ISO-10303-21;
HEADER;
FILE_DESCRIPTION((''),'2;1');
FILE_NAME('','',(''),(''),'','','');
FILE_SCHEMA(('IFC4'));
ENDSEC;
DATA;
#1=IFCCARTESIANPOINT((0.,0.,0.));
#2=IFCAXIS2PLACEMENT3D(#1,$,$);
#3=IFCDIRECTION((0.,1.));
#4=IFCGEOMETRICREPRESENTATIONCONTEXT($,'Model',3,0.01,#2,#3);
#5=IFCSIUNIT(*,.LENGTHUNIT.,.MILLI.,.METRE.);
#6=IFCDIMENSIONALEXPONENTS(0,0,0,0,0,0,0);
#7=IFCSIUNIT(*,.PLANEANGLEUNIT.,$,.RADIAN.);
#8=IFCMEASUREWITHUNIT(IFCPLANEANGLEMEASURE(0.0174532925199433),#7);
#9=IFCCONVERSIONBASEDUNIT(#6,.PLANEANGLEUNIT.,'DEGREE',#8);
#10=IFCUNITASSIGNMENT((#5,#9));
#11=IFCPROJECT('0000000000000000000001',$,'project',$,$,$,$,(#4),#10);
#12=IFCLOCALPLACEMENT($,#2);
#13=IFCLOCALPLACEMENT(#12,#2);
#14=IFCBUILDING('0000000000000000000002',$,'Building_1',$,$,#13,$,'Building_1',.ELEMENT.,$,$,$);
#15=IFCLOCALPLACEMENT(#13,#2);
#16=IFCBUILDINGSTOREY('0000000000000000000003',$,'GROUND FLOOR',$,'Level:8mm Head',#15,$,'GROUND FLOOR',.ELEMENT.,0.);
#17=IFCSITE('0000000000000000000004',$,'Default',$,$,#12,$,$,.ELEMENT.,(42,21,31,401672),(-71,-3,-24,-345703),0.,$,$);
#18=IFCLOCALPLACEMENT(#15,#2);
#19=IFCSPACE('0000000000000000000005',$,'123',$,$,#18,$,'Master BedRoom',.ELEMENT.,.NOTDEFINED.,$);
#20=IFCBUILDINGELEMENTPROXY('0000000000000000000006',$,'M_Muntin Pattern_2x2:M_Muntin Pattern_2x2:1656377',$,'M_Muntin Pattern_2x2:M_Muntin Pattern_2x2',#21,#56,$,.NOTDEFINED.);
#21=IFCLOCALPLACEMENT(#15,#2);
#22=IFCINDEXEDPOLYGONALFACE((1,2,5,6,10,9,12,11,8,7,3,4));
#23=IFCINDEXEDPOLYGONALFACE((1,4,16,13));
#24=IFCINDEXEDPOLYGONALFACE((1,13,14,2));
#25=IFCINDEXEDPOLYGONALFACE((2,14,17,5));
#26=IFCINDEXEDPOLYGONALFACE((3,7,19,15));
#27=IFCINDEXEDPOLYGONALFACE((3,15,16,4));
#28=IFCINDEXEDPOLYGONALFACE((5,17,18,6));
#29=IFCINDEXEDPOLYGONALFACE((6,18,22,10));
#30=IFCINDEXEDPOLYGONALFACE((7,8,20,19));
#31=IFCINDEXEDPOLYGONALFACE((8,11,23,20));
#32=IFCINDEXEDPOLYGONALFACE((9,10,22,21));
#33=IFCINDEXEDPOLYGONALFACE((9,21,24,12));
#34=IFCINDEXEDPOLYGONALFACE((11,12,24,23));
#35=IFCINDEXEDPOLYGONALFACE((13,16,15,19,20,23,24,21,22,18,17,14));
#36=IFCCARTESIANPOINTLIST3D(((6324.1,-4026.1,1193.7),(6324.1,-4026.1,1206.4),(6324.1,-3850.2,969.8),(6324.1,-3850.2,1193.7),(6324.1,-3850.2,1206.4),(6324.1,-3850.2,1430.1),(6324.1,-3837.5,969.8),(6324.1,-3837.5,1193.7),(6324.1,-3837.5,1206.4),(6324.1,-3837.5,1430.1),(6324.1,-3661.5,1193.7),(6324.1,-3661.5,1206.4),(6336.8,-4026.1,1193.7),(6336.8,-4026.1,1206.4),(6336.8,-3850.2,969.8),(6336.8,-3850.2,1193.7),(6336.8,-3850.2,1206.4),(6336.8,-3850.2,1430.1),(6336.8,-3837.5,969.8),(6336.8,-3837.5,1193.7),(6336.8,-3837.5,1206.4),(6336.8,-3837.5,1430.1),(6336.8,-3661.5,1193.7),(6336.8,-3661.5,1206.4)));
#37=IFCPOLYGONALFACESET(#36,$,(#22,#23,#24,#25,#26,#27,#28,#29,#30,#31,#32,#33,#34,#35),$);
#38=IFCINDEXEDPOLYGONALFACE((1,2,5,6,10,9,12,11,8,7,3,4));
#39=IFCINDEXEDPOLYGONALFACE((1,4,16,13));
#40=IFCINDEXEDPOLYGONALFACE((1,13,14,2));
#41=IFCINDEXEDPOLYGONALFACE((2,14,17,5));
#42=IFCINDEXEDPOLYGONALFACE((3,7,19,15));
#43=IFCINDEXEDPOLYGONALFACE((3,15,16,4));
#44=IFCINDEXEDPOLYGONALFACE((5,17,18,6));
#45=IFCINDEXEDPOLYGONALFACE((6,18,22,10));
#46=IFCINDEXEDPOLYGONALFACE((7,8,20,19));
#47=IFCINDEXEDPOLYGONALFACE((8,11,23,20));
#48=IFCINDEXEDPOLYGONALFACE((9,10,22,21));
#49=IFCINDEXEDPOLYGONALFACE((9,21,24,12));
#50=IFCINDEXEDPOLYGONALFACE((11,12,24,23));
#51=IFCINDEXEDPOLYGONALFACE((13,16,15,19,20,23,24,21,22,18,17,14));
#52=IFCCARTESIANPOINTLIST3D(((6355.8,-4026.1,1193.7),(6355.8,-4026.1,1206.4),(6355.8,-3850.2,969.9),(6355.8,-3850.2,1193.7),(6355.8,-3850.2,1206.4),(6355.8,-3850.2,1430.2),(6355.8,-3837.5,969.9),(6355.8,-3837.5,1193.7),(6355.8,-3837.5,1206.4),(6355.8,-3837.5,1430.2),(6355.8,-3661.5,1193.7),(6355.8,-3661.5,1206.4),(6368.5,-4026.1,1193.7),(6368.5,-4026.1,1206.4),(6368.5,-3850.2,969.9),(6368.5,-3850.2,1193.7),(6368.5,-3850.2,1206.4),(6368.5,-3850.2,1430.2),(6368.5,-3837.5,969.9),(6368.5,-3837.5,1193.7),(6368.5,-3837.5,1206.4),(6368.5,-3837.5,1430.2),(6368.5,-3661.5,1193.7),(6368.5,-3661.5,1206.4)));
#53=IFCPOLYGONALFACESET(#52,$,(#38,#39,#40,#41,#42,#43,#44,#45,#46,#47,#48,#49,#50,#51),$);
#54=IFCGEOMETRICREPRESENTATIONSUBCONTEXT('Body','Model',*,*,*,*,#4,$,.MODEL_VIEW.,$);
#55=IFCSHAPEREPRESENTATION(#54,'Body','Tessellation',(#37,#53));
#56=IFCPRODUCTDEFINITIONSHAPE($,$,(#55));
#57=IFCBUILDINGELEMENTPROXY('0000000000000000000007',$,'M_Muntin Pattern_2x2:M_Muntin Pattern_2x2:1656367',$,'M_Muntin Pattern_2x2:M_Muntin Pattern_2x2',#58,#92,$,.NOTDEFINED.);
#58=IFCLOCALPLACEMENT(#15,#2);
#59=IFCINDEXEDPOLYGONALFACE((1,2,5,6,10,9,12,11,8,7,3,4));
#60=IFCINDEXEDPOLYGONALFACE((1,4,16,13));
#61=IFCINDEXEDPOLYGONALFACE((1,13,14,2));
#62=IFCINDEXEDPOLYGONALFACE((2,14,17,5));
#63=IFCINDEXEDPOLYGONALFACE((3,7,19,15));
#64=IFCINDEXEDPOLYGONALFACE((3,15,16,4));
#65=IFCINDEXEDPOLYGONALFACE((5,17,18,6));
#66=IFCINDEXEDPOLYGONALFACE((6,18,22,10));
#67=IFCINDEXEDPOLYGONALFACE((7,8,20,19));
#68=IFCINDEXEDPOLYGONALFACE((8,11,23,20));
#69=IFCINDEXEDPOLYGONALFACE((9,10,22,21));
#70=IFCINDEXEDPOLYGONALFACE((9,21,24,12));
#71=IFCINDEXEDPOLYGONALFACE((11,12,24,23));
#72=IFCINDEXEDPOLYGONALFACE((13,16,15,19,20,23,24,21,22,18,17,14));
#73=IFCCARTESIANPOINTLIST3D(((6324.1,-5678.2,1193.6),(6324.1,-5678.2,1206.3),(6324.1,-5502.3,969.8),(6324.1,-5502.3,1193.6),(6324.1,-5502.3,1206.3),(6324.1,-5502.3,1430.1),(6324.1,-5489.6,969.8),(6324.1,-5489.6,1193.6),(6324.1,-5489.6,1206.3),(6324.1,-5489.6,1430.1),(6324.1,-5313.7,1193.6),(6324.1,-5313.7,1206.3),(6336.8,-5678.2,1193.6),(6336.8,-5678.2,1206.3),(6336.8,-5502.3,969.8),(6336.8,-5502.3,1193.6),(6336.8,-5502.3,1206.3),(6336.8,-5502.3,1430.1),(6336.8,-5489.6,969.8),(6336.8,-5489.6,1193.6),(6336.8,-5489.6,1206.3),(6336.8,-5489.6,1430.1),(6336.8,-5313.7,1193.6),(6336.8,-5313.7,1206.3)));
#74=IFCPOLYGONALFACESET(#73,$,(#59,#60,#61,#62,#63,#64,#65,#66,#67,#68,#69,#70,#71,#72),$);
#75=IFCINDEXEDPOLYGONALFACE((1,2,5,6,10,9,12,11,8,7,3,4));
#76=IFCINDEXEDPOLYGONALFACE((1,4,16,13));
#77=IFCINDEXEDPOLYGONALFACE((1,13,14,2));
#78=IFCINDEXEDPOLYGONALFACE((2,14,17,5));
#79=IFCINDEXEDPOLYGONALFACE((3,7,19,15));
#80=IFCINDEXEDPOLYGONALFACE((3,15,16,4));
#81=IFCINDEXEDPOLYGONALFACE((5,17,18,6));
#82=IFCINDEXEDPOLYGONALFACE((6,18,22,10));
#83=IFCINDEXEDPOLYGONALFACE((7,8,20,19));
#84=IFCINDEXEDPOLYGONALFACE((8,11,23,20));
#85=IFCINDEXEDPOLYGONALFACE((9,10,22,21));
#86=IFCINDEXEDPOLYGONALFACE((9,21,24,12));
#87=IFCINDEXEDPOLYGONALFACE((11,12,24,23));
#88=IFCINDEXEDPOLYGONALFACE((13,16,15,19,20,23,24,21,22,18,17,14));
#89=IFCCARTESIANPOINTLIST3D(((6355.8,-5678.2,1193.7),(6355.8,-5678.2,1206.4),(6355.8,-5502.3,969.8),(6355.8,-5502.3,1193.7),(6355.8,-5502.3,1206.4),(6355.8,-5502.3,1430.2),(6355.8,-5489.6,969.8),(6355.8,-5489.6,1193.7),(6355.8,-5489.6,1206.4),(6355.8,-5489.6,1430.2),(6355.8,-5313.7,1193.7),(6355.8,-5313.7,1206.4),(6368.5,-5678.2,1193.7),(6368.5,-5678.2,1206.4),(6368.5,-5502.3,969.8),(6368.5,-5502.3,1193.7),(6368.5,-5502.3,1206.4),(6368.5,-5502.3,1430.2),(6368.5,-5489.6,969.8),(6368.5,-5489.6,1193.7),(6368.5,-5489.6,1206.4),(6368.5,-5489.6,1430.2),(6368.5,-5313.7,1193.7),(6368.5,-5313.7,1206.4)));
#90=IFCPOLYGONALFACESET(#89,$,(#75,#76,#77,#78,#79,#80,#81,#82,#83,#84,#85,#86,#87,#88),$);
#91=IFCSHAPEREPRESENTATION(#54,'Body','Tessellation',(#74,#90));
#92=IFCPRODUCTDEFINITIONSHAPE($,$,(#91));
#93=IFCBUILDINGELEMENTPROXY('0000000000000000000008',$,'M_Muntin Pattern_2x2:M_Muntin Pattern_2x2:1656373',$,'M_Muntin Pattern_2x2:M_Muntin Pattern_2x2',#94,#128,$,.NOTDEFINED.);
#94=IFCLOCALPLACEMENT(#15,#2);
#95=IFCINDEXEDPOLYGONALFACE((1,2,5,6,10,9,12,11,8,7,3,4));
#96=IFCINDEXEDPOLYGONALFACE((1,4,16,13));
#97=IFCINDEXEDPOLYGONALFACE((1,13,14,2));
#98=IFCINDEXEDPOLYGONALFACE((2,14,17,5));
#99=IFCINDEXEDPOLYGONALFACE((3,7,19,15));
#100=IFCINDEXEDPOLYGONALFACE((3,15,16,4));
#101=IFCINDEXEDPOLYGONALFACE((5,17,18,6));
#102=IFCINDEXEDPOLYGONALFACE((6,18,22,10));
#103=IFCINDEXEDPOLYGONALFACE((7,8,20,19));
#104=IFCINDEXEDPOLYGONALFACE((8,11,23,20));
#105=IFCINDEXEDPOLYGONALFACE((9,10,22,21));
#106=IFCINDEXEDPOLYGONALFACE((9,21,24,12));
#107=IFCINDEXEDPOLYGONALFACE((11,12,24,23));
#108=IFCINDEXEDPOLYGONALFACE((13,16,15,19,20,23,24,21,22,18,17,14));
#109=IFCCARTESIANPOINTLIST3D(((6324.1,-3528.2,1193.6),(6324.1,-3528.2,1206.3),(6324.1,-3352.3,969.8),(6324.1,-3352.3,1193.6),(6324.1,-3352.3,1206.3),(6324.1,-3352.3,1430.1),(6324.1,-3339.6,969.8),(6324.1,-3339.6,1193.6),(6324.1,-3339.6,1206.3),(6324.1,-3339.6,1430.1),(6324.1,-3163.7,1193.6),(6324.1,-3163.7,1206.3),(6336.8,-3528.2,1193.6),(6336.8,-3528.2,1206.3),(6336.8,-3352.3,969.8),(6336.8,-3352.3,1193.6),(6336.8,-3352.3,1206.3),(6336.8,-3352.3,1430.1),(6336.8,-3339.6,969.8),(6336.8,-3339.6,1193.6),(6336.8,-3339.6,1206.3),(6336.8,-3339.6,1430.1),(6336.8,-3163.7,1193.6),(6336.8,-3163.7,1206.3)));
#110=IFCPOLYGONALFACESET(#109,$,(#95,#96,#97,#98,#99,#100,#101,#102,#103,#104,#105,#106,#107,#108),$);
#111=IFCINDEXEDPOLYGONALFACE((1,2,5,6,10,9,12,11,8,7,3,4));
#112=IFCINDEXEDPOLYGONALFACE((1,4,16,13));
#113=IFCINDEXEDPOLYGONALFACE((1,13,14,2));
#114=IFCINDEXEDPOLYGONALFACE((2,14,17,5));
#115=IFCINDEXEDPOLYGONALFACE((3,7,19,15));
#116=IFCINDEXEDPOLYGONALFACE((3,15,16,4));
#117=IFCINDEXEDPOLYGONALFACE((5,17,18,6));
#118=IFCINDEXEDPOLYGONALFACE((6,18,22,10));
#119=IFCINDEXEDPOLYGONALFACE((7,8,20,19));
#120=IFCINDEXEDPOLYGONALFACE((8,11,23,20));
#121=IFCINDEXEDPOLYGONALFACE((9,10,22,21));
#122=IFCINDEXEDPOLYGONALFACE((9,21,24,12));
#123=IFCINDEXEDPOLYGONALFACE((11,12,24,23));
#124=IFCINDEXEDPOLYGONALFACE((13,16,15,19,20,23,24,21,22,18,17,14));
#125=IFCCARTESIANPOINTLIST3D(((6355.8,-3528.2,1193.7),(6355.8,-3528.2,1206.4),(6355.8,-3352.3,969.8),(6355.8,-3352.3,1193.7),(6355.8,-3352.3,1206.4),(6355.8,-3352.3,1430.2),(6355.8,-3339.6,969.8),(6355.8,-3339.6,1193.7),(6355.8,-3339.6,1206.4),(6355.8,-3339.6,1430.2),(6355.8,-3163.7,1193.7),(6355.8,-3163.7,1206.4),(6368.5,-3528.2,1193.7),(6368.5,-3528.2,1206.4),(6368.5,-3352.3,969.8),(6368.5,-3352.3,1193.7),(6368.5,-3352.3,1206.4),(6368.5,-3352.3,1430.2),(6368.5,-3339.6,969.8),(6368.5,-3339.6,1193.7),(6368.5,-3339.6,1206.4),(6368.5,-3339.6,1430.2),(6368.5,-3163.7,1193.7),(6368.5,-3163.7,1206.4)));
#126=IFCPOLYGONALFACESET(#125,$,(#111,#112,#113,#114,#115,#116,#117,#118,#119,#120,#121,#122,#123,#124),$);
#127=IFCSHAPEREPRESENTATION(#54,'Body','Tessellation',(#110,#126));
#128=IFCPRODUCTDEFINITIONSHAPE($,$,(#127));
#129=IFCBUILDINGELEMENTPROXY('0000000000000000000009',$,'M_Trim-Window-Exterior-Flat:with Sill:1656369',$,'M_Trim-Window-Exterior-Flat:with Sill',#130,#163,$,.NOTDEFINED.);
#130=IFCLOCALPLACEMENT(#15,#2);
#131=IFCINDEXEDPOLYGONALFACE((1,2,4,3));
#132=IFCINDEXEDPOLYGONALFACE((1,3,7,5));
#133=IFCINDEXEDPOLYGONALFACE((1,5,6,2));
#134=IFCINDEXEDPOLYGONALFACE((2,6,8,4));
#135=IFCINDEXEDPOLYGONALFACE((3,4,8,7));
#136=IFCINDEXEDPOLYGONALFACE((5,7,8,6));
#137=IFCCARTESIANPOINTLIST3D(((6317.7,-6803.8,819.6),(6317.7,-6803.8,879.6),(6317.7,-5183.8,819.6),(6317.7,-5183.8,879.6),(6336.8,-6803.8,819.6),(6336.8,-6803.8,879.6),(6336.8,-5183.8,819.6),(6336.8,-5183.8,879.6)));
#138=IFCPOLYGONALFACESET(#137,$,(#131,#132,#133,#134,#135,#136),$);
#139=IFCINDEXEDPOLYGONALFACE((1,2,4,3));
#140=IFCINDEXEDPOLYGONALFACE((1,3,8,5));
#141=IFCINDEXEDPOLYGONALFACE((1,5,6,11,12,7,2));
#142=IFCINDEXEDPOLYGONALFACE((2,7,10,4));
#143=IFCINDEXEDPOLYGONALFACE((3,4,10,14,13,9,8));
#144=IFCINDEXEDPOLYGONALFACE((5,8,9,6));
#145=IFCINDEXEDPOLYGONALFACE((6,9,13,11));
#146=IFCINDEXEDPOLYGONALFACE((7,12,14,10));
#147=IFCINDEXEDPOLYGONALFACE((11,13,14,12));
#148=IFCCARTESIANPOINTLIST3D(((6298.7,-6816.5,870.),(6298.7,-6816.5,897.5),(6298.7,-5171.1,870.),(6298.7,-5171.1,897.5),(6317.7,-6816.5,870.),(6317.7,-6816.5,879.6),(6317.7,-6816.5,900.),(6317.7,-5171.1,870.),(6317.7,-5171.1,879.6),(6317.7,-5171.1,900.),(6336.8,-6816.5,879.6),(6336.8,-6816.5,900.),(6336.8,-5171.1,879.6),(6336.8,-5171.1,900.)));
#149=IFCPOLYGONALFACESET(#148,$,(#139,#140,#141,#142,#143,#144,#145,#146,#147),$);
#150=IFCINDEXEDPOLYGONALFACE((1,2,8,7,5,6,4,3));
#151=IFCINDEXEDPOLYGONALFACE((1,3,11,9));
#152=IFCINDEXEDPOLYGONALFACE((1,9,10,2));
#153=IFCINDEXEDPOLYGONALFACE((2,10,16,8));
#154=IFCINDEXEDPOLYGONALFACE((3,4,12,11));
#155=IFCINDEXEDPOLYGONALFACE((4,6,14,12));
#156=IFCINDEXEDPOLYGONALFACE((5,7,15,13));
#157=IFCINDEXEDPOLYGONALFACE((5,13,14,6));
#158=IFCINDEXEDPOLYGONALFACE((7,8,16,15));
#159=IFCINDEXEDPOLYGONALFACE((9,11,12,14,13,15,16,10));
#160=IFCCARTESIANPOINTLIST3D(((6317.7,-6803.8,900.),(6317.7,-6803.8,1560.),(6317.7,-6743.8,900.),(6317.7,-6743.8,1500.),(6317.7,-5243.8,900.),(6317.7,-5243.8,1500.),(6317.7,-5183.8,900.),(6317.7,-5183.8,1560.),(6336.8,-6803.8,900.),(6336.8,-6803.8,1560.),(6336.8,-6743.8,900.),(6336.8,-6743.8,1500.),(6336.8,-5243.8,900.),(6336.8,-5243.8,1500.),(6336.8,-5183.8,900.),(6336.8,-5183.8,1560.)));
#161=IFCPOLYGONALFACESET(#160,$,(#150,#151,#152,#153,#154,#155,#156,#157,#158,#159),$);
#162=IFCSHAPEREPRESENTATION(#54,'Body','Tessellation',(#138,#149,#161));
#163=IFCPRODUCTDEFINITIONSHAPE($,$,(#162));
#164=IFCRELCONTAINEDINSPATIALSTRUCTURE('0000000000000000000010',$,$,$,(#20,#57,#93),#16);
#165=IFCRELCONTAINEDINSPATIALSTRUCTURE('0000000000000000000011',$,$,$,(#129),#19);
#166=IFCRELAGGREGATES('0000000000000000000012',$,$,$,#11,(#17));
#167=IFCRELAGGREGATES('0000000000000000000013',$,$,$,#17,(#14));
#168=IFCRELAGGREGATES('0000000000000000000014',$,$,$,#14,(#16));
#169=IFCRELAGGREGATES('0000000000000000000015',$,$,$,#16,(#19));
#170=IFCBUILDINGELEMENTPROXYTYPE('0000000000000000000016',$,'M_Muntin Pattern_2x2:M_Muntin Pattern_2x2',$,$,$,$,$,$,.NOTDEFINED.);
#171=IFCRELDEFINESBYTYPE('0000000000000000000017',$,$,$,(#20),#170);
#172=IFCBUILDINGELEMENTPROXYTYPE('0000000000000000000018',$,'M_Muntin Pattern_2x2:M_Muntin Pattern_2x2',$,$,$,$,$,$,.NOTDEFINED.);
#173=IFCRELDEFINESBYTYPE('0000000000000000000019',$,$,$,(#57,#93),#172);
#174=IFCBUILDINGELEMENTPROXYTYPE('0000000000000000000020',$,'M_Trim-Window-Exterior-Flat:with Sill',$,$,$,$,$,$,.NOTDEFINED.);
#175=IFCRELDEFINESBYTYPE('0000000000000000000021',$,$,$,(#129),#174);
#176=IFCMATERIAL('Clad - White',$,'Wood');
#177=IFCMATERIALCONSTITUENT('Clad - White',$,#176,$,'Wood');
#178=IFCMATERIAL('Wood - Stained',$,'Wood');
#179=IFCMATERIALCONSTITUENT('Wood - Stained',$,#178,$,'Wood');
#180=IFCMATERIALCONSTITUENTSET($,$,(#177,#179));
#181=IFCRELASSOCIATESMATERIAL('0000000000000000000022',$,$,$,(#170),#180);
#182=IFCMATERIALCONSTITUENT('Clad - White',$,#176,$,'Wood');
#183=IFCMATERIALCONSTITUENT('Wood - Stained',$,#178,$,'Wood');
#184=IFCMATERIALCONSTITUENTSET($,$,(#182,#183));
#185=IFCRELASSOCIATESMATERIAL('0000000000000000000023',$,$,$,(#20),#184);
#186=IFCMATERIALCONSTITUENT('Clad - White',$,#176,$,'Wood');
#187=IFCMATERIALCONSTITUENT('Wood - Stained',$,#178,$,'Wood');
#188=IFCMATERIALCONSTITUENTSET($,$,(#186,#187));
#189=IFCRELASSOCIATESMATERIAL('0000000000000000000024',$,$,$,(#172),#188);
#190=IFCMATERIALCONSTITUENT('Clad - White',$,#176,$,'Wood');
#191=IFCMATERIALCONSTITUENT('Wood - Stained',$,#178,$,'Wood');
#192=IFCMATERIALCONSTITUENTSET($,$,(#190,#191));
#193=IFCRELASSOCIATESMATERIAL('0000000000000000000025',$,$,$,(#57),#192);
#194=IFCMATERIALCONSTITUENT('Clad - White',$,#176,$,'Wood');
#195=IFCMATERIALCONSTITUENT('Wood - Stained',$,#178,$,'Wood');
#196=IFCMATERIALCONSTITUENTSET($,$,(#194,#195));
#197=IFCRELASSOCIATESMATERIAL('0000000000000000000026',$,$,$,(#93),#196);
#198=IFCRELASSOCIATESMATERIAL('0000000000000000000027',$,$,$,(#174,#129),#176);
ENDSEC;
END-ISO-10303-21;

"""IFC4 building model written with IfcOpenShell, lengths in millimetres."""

from ifc_helpers import new_model, entity, si_unit, converted_unit, direction, frame, origin, place, context, subcontext, project, spatial, indexed_curve, outline, extrude, source, transform, mapped, material, constituent, constituent_set, type_object, type_shapes, element, save


model = new_model("IFC4")

# Units and contexts
model_context = context("Model", 3, precision=0.01, world=origin(), true_north=direction((0.0, 1.0)))
body_context = subcontext(model_context, "Body", "Model", "MODEL_VIEW")
ifc_project = project(units=[si_unit("LENGTHUNIT", "METRE", prefix="MILLI"), converted_unit("PLANEANGLEUNIT", "DEGREE", entity("IfcPlaneAngleMeasure", 0.0174532925199433), si_unit("PLANEANGLEUNIT", "RADIAN"), dimensions=[0, 0, 0, 0, 0, 0, 0])], contexts=[model_context])

# Site, building, storey
site_placement = place(None, origin())
site = spatial("IfcSite", under=ifc_project, at=site_placement, Name="Default", CompositionType="ELEMENT", RefLatitude=(42, 21, 31, 401672), RefLongitude=(-71, -3, -24, -345703), RefElevation=0.0)
building_placement = place(site_placement, origin())
building = spatial("IfcBuilding", under=site, at=building_placement, Name="Building_1", LongName="Building_1", CompositionType="ELEMENT")
storey_placement = place(building_placement, origin())
storey = spatial("IfcBuildingStorey", under=building, at=storey_placement, Name="GROUND FLOOR", ObjectType="Level:8mm Head", LongName="GROUND FLOOR", CompositionType="ELEMENT", Elevation=0.0)

# Shared definitions
ifc_material_1 = material(Name="Wood - Stained", Category="Wood")

# Shared definitions
space_1_placement = place(storey_placement, origin())
space_1 = spatial("IfcSpace", under=storey, at=space_1_placement, Name="123", LongName="Master BedRoom", CompositionType="ELEMENT", PredefinedType="NOTDEFINED")

# Building element proxies
ifc_material_2 = material(Name="Clad - White", Category="Wood")
ifc_constituent_1 = constituent(ifc_material_2, Name="Clad - White", Category="Wood")
ifc_constituent_2 = constituent(ifc_material_1, Name="Wood - Stained", Category="Wood")
ifc_constituent_set_1 = constituent_set(constituents=[ifc_constituent_1, ifc_constituent_2])
building_element_proxy_type_1 = type_object("IfcBuildingElementProxyType", Name="M_Muntin Pattern_2x2:M_Muntin Pattern_2x2", PredefinedType="NOTDEFINED", material=ifc_constituent_set_1)
shared_shape_1 = source(origin(), body_context, "Body", "SweptSolid", [
    extrude(outline(indexed_curve([(6.4, -6.4), (230.1, -6.4), (230.1, 6.3), (6.4, 6.3), (6.4, 182.3), (-6.3, 182.3), (-6.3, 6.3), (-230.2, 6.3), (-230.2, -6.4), (-6.3, -6.4), (-6.3, -182.3), (6.4, -182.3), (6.4, -6.4)], self_intersect=False)), frame((0.0, 9.5, 230.1), z_axis=(0.0, 1.0, 0.0), x_axis=(0.0, 0.0, 1.0)), (0.0, 0.0, 1.0), 12.7),
    extrude(outline(indexed_curve([(6.4, -6.4), (230.2, -6.4), (230.2, 6.3), (6.4, 6.3), (6.4, 182.3), (-6.3, 182.3), (-6.3, 6.3), (-230.2, 6.3), (-230.2, -6.4), (-6.3, -6.4), (-6.3, -182.3), (6.4, -182.3), (6.4, -6.4)], self_intersect=False)), frame((0.0, -22.2, 230.2), z_axis=(0.0, 1.0, 0.0), x_axis=(0.0, 0.0, 1.0)), (0.0, 0.0, 1.0), 12.7),
])
type_shapes(building_element_proxy_type_1, [shared_shape_1])
ifc_constituent_3 = constituent(ifc_material_2, Name="Clad - White", Category="Wood")
ifc_constituent_4 = constituent(ifc_material_1, Name="Wood - Stained", Category="Wood")
ifc_constituent_set_2 = constituent_set(constituents=[ifc_constituent_3, ifc_constituent_4])
proxy_1_placement = place(storey_placement, frame((6346.3, -3843.8, 969.9), z_axis=(0.0, 0.0, 1.0), x_axis=(0.0, 1.0, 0.0)))
element("IfcBuildingElementProxy", 1, at=proxy_1_placement, inside=storey, type_object=building_element_proxy_type_1, material=ifc_constituent_set_2, Name="M_Muntin Pattern_2x2:M_Muntin Pattern_2x2:1656377", ObjectType="M_Muntin Pattern_2x2:M_Muntin Pattern_2x2", PredefinedType="NOTDEFINED", context=body_context, shape_type="MappedRepresentation", body=[
    mapped(shared_shape_1, transform((0.0, 0.0, 0.0), scale=1.0)),
])
ifc_constituent_5 = constituent(ifc_material_2, Name="Clad - White", Category="Wood")
ifc_constituent_6 = constituent(ifc_material_1, Name="Wood - Stained", Category="Wood")
ifc_constituent_set_3 = constituent_set(constituents=[ifc_constituent_5, ifc_constituent_6])
ifc_constituent_7 = constituent(ifc_material_2, Name="Clad - White", Category="Wood")
ifc_constituent_8 = constituent(ifc_material_1, Name="Wood - Stained", Category="Wood")
ifc_constituent_set_4 = constituent_set(constituents=[ifc_constituent_7, ifc_constituent_8])
building_element_proxy_type_2 = type_object("IfcBuildingElementProxyType", Name="M_Muntin Pattern_2x2:M_Muntin Pattern_2x2", PredefinedType="NOTDEFINED", material=ifc_constituent_set_4)
shared_shape_2 = source(origin(), body_context, "Body", "SweptSolid", [
    extrude(outline(indexed_curve([(6.4, -6.4), (230.1, -6.4), (230.1, 6.3), (6.4, 6.3), (6.4, 182.3), (-6.3, 182.3), (-6.3, 6.3), (-230.2, 6.3), (-230.2, -6.4), (-6.3, -6.4), (-6.3, -182.3), (6.4, -182.3), (6.4, -6.4)], self_intersect=False)), frame((0.0, -22.2, 230.1), z_axis=(0.0, 1.0, 0.0), x_axis=(0.0, 0.0, 1.0)), (0.0, 0.0, 1.0), 12.7),
    extrude(outline(indexed_curve([(6.4, -6.4), (230.2, -6.4), (230.2, 6.3), (6.4, 6.3), (6.4, 182.3), (-6.3, 182.3), (-6.3, 6.3), (-230.2, 6.3), (-230.2, -6.4), (-6.3, -6.4), (-6.3, -182.3), (6.4, -182.3), (6.4, -6.4)], self_intersect=False)), frame((0.0, 9.5, 230.2), z_axis=(0.0, 1.0, 0.0), x_axis=(0.0, 0.0, 1.0)), (0.0, 0.0, 1.0), 12.7),
])
type_shapes(building_element_proxy_type_2, [shared_shape_2])
proxy_2_placement = place(storey_placement, frame((6346.3, -5495.9, 969.8), z_axis=(0.0, 0.0, 1.0), x_axis=(0.0, -1.0, 0.0)))
element("IfcBuildingElementProxy", 2, at=proxy_2_placement, inside=storey, type_object=building_element_proxy_type_2, material=ifc_constituent_set_3, Name="M_Muntin Pattern_2x2:M_Muntin Pattern_2x2:1656367", ObjectType="M_Muntin Pattern_2x2:M_Muntin Pattern_2x2", PredefinedType="NOTDEFINED", context=body_context, shape_type="MappedRepresentation", body=[
    mapped(shared_shape_2, transform((0.0, 0.0, 0.0), scale=1.0)),
])
ifc_constituent_9 = constituent(ifc_material_2, Name="Clad - White", Category="Wood")
ifc_constituent_10 = constituent(ifc_material_1, Name="Wood - Stained", Category="Wood")
ifc_constituent_set_5 = constituent_set(constituents=[ifc_constituent_9, ifc_constituent_10])
proxy_3_placement = place(storey_placement, frame((6346.3, -3345.9, 969.8), z_axis=(0.0, 0.0, 1.0), x_axis=(0.0, -1.0, 0.0)))
element("IfcBuildingElementProxy", 3, at=proxy_3_placement, inside=storey, type_object=building_element_proxy_type_2, material=ifc_constituent_set_5, Name="M_Muntin Pattern_2x2:M_Muntin Pattern_2x2:1656373", ObjectType="M_Muntin Pattern_2x2:M_Muntin Pattern_2x2", PredefinedType="NOTDEFINED", context=body_context, shape_type="MappedRepresentation", body=[
    mapped(shared_shape_2, transform((0.0, 0.0, 0.0), scale=1.0)),
])
building_element_proxy_type_3 = type_object("IfcBuildingElementProxyType", Name="M_Trim-Window-Exterior-Flat:with Sill", PredefinedType="NOTDEFINED", material=ifc_material_2)
shared_shape_3 = source(origin(), body_context, "Body", "SweptSolid", [
    extrude(outline(indexed_curve([(-30.0, -810.0), (30.0, -810.0), (30.0, 810.0), (-30.0, 810.0), (-30.0, -810.0)], self_intersect=False)), frame((0.0, 650.4, 0.0), z_axis=(0.0, 0.0, 1.0), x_axis=(0.0, 1.0, 0.0)), (0.0, 0.0, 1.0), 19.1),
    extrude(outline(indexed_curve([(-15.2, -19.0), (12.3, -19.0), (14.8, 0.0), (14.8, 19.0), (-5.7, 19.0), (-5.7, 0.0), (-15.2, 0.0), (-15.2, -19.0)], self_intersect=False)), frame((-822.7, 614.8, 19.0), z_axis=(1.0, 0.0, 0.0), x_axis=(0.0, -1.0, 0.0)), (0.0, 0.0, 1.0), 1645.4),
    extrude(outline(indexed_curve([(-810.0, -345.0), (810.0, -345.0), (810.0, 315.0), (750.0, 315.0), (750.0, -285.0), (-750.0, -285.0), (-750.0, 315.0), (-810.0, 315.0), (-810.0, -345.0)], self_intersect=False)), frame((0.0, 285.0, 0.0)), (0.0, 0.0, 1.0), 19.1),
])
type_shapes(building_element_proxy_type_3, [shared_shape_3])
for number, where, z_axis, x_axis, name in (
    (4, (6336.8, -5993.8, 1500.0), (-1.0, 0.0, 0.0), (0.0, 1.0, 0.0), "M_Trim-Window-Exterior-Flat:with Sill:1656369"),
):
    element("IfcBuildingElementProxy", number, at=place(space_1_placement, frame(where, z_axis=z_axis, x_axis=x_axis)), inside=space_1, type_object=building_element_proxy_type_3, material=ifc_material_2, Name=name, ObjectType="M_Trim-Window-Exterior-Flat:with Sill", PredefinedType="NOTDEFINED", context=body_context, shape_type="MappedRepresentation", body=[
        mapped(shared_shape_3, transform((0.0, 0.0, 0.0), scale=1.0)),
    ])

save(model, "model.ifc")
